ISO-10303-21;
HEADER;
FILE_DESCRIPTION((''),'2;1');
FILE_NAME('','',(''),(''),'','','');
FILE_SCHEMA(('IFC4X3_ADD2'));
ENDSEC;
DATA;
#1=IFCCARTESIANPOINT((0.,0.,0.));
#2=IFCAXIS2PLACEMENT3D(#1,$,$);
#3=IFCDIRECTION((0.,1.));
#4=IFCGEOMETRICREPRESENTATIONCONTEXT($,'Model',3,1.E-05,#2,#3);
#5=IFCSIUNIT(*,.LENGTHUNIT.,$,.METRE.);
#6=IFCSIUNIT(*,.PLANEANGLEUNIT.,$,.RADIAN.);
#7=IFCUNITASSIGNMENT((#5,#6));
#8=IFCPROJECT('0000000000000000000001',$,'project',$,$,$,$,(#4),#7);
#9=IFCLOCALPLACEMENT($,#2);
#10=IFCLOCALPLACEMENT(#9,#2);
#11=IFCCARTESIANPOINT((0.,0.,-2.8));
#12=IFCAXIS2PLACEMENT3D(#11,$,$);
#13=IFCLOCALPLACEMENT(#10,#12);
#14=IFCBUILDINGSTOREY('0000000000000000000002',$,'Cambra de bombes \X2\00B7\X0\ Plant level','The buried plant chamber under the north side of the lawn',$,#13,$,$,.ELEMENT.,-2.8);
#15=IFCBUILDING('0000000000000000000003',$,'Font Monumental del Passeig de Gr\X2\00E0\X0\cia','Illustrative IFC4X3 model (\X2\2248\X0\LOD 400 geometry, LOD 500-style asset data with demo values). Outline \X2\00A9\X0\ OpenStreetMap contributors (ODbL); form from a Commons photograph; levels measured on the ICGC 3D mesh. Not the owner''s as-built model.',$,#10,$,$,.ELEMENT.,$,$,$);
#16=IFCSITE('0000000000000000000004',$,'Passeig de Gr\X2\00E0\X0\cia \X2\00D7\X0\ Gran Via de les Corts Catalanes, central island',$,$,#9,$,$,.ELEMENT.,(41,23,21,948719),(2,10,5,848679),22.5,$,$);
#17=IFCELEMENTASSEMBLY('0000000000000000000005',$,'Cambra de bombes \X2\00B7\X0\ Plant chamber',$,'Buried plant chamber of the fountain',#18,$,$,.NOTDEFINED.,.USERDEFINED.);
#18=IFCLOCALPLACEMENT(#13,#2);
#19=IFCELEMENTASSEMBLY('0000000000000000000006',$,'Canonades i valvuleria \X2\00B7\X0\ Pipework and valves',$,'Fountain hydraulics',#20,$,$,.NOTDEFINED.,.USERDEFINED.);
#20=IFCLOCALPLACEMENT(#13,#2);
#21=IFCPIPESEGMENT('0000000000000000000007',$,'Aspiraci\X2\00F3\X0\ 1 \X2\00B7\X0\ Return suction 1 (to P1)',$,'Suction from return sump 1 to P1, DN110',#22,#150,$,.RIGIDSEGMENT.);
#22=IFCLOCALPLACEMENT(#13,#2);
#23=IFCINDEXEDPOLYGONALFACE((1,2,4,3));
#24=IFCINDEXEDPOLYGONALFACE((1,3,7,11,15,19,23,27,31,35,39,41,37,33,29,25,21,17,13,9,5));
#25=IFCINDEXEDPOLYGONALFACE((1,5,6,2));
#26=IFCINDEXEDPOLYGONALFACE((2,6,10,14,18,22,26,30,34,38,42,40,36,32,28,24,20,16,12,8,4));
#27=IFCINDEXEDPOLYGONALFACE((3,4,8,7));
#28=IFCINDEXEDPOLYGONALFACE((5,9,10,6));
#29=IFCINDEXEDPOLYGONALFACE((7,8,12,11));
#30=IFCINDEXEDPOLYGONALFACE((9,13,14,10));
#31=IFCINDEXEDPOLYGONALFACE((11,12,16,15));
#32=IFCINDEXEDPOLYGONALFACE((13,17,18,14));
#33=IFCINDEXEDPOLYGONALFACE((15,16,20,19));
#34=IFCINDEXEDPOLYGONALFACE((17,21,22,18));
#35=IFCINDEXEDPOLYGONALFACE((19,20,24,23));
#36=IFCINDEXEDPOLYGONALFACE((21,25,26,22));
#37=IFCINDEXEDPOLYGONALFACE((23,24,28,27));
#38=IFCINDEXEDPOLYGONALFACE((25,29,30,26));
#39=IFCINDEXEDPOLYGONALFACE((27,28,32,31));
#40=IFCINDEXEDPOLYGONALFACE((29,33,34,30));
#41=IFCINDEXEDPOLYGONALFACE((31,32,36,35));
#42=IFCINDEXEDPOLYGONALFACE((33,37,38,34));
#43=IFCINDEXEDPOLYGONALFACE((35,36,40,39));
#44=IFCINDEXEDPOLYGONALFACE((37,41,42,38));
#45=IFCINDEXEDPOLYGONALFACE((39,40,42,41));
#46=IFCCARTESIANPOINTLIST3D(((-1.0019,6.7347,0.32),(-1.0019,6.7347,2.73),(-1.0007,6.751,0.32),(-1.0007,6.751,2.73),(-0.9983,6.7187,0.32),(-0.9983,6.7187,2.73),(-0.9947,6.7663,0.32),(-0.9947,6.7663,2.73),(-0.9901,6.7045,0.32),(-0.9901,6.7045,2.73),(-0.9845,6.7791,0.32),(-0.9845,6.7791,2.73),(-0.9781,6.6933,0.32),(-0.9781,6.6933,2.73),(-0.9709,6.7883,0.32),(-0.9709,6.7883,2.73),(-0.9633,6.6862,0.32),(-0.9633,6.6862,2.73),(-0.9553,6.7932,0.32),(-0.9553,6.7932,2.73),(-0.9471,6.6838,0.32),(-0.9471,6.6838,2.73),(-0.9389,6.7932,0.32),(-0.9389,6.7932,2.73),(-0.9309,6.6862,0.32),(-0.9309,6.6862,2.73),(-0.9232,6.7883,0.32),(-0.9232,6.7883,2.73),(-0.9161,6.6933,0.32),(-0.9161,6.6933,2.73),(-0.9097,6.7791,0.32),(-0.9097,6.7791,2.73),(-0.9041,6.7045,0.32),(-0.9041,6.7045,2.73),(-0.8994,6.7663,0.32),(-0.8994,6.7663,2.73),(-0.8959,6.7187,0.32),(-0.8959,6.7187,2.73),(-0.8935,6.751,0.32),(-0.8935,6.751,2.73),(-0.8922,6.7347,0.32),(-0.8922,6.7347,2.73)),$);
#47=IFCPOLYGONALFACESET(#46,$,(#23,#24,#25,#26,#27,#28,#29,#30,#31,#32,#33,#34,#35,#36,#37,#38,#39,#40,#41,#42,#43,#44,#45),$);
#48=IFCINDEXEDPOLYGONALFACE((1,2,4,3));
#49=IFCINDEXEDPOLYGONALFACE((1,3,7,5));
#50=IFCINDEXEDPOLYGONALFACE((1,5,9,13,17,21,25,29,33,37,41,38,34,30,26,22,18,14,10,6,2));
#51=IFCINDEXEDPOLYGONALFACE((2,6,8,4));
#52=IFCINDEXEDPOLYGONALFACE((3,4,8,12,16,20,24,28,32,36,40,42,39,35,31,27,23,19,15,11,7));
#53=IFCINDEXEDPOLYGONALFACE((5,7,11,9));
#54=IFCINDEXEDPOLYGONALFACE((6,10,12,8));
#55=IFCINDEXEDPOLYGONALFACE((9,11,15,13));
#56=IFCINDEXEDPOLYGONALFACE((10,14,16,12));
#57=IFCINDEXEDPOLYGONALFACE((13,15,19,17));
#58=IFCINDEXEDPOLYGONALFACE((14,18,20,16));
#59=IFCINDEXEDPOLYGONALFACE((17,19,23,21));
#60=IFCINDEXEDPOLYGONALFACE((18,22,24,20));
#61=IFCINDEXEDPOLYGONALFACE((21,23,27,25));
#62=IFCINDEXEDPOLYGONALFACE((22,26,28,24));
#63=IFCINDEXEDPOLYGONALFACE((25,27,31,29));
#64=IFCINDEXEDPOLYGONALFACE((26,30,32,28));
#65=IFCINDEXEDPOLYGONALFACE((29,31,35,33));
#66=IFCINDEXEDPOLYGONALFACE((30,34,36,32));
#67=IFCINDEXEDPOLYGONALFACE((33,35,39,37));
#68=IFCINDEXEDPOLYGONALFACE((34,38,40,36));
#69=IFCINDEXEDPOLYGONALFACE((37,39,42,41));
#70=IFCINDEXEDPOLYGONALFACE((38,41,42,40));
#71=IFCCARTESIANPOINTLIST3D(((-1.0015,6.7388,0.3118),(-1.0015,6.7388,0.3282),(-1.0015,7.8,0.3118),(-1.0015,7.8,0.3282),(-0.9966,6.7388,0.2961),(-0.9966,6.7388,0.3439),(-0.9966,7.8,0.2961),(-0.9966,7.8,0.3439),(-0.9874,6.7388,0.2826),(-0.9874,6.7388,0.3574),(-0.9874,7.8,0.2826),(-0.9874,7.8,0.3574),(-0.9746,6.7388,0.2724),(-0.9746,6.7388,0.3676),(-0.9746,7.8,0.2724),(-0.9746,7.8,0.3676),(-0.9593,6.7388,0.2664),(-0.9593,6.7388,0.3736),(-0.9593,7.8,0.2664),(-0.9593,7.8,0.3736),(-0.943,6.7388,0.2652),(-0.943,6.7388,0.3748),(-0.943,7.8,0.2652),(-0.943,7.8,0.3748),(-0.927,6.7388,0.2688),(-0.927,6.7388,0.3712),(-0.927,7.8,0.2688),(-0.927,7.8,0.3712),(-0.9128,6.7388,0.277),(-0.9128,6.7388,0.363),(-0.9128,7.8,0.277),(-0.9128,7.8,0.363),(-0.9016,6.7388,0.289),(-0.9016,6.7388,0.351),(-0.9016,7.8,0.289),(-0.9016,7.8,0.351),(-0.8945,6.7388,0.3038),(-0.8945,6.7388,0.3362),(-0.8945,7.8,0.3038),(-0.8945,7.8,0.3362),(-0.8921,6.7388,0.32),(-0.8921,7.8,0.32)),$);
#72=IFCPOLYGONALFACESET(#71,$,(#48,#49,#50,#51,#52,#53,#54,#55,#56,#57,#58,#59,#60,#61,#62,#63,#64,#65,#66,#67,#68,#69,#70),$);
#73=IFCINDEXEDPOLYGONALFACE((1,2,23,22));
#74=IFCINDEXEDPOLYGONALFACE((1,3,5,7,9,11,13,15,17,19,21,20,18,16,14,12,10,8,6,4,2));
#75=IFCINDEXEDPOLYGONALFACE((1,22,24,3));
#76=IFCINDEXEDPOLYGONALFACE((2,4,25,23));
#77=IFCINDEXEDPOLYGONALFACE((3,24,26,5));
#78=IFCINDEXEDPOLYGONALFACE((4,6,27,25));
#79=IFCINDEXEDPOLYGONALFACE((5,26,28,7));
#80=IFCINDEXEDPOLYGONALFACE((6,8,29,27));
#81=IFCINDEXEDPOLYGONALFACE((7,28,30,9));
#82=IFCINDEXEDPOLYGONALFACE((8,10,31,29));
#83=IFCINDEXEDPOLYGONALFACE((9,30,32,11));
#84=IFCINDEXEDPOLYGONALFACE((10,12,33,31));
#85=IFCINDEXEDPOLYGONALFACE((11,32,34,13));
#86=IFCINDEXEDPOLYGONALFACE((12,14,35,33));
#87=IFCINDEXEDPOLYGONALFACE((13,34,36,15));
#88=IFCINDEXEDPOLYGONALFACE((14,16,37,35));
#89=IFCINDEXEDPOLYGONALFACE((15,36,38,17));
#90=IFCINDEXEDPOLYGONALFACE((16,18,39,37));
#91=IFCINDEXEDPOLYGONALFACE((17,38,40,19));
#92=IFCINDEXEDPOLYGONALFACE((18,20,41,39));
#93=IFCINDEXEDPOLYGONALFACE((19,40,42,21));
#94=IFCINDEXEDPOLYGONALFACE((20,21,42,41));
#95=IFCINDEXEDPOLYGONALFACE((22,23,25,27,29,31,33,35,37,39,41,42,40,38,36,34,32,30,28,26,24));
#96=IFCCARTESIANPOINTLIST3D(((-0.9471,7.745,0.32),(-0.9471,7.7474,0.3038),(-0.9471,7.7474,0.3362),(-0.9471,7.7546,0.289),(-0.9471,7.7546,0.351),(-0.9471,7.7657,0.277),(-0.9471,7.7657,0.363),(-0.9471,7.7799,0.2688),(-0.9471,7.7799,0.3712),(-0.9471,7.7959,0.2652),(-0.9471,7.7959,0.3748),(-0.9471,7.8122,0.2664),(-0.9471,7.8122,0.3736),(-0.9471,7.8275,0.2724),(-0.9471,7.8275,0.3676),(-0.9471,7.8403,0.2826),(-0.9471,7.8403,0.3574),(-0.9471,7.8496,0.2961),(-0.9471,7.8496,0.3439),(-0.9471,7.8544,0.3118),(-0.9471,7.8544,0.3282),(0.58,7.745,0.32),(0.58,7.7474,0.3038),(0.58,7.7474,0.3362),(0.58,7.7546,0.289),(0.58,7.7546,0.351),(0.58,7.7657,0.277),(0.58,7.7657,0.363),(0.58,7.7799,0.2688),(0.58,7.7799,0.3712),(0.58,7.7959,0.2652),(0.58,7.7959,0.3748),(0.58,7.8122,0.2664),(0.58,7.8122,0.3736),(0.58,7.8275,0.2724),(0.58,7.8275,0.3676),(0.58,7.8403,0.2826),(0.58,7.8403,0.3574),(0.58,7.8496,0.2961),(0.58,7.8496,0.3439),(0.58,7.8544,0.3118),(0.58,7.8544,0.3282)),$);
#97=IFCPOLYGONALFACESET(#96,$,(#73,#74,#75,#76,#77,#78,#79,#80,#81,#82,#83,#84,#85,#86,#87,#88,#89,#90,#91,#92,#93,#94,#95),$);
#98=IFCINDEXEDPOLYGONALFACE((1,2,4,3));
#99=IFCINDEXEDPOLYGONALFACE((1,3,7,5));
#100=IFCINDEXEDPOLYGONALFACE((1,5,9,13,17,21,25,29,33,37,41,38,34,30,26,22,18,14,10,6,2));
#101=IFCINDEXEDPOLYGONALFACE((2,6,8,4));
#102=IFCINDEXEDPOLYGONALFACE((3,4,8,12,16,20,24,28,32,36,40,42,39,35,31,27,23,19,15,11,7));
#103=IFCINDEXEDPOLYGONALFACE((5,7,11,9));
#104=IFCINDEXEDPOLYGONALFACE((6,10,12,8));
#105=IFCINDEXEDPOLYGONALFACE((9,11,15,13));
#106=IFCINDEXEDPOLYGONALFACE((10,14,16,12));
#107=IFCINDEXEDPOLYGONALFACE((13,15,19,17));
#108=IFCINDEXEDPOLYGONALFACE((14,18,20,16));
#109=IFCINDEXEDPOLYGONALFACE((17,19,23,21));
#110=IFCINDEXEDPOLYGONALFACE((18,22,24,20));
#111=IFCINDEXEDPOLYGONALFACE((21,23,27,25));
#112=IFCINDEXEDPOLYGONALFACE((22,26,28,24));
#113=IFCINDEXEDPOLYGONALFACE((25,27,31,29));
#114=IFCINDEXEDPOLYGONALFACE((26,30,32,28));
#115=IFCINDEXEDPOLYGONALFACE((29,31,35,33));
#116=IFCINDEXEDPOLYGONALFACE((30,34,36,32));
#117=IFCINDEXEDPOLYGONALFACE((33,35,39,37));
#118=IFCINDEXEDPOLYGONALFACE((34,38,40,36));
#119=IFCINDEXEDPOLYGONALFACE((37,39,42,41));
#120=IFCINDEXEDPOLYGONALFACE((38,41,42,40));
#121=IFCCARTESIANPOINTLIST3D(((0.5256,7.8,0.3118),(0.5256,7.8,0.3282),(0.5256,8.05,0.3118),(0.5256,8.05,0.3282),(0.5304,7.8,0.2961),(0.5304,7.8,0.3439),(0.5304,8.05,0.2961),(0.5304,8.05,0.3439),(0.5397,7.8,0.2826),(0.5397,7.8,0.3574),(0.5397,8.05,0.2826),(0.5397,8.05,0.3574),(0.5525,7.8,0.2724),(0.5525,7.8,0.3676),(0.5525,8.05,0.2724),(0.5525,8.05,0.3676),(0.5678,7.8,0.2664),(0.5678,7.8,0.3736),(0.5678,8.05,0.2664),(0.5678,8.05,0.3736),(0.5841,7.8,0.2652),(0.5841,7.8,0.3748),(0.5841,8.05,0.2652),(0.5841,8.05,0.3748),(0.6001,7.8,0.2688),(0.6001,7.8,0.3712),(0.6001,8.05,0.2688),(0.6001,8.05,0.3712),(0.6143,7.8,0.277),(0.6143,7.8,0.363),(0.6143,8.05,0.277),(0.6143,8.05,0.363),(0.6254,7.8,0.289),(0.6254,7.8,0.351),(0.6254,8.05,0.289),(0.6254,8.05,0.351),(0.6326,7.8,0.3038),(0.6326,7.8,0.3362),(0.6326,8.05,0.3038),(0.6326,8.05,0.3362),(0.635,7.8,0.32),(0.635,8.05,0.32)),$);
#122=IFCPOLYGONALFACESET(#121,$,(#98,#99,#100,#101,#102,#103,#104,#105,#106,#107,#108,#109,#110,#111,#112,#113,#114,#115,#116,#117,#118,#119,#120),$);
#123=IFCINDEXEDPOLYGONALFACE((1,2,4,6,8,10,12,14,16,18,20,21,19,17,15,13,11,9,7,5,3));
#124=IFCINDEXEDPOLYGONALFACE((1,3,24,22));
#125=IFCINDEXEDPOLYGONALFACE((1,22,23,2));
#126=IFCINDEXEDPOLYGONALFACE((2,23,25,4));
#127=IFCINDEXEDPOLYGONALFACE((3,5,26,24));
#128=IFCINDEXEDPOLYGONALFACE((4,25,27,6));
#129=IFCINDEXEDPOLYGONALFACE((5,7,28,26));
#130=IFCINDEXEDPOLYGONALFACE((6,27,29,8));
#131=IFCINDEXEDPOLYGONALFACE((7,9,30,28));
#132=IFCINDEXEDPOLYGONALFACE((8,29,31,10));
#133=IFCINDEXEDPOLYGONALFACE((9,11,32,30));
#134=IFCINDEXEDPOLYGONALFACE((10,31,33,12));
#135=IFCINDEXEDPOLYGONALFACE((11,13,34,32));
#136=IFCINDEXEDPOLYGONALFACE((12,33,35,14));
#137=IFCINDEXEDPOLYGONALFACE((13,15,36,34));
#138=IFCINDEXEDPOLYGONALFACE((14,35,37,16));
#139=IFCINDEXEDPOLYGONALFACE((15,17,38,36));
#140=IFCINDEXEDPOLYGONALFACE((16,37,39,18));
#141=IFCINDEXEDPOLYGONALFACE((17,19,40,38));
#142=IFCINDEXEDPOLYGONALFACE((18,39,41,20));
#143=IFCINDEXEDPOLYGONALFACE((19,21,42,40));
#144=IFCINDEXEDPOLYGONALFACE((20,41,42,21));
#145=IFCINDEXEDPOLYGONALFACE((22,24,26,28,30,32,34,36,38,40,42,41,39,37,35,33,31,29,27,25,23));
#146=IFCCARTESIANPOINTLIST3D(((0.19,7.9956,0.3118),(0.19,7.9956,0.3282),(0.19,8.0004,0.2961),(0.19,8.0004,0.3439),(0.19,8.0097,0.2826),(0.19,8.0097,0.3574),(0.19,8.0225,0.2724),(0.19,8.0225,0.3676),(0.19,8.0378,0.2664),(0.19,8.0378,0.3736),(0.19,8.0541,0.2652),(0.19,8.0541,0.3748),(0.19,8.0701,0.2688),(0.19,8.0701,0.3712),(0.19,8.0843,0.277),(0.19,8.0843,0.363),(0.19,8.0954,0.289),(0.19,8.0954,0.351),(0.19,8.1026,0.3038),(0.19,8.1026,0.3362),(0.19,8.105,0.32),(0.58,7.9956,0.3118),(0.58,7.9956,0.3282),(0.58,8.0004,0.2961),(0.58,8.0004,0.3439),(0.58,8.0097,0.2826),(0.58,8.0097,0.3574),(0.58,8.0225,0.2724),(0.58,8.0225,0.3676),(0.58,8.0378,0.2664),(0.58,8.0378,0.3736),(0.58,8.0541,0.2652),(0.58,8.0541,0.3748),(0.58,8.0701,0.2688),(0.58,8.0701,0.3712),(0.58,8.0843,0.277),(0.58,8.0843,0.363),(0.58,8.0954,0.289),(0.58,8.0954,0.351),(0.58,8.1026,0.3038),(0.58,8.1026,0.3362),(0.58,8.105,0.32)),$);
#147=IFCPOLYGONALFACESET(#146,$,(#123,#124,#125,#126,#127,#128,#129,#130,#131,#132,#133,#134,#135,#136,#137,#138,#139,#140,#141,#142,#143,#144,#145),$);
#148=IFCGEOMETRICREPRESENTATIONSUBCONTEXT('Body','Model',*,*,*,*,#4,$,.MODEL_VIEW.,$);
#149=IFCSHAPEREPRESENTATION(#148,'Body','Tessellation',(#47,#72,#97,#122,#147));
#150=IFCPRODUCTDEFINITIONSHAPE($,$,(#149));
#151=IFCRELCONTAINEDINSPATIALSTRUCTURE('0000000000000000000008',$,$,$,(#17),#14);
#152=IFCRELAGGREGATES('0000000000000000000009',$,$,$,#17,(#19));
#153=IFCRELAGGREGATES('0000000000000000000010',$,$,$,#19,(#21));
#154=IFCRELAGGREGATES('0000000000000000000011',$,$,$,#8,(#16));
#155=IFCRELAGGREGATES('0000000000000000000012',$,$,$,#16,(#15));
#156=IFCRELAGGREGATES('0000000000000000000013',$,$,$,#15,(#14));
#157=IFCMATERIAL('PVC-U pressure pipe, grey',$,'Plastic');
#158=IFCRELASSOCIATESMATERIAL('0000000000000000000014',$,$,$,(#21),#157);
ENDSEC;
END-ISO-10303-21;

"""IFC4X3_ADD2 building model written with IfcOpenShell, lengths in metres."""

from ifc_helpers import new_model, si_unit, direction, frame, origin, origin_2d_with_axis, place, context, subcontext, project, spatial, circle, extrude, material, element, aggregate, save


model = new_model("IFC4X3_ADD2")

# Units and contexts
model_context = context("Model", 3, precision=1e-05, world=origin(), true_north=direction((0.0, 1.0)))
body_context = subcontext(model_context, "Body", "Model", "MODEL_VIEW")
ifc_project = project(units=[si_unit("LENGTHUNIT", "METRE"), si_unit("PLANEANGLEUNIT", "RADIAN")], contexts=[model_context])

# Site, building, storey
site_placement = place(None, origin())
site = spatial("IfcSite", under=ifc_project, at=site_placement, Name="Passeig de Gràcia × Gran Via de les Corts Catalanes, central island", CompositionType="ELEMENT", RefLatitude=(41, 23, 21, 948719), RefLongitude=(2, 10, 5, 848679), RefElevation=22.5)
building_placement = place(site_placement, origin())
building = spatial("IfcBuilding", under=site, at=building_placement, Name="Font Monumental del Passeig de Gràcia", Description="Illustrative IFC4X3 model (≈LOD 400 geometry, LOD 500-style asset data with demo values). Outline © OpenStreetMap contributors (ODbL); form from a Commons photograph; levels measured on the ICGC 3D mesh. Not the owner's as-built model.", CompositionType="ELEMENT")
storey_placement = place(building_placement, frame((0.0, 0.0, -2.8)))
storey = spatial("IfcBuildingStorey", under=building, at=storey_placement, Name="Cambra de bombes · Plant level", Description="The buried plant chamber under the north side of the lawn", CompositionType="ELEMENT", Elevation=-2.8)

# Element assemblies, pipe segment
assembly_1_placement = place(building_placement, origin())
assembly_1 = element("IfcElementAssembly", 1, at=assembly_1_placement, inside=storey, Name="Cambra de bombes · Plant chamber", ObjectType="Buried plant chamber of the fountain", AssemblyPlace="NOTDEFINED", PredefinedType="USERDEFINED")
assembly_2_placement = place(building_placement, origin())
assembly_2 = element("IfcElementAssembly", 2, at=assembly_2_placement, Name="Canonades i valvuleria · Pipework and valves", ObjectType="Fountain hydraulics", AssemblyPlace="NOTDEFINED", PredefinedType="USERDEFINED")
aggregate(assembly_1, [assembly_2])
ifc_material_1 = material(Name="PVC-U pressure pipe, grey", Category="Plastic")
pipe_segment_1_placement = place(building_placement, origin())
pipe_segment_1 = element("IfcPipeSegment", 3, at=pipe_segment_1_placement, material=ifc_material_1, Name="Aspiració 1 · Return suction 1 (to P1)", ObjectType="Suction from return sump 1 to P1, DN110", PredefinedType="RIGIDSEGMENT", context=body_context, shape_type="SweptSolid", body=[
    extrude(circle(Radius=0.055, at=origin_2d_with_axis()), frame((-0.9471, 6.7388, -0.07), z_axis=(0.0, 0.0, -1.0), x_axis=(0.0, -1.0, 0.0)), (0.0, 0.0, 1.0), 2.41),
    extrude(circle(Radius=0.055, at=origin_2d_with_axis()), frame((-0.9471, 6.7388, -2.48), z_axis=(0.0, 1.0, 0.0), x_axis=(1.0, 0.0, 0.0)), (0.0, 0.0, 1.0), 1.0612),
    extrude(circle(Radius=0.055, at=origin_2d_with_axis()), frame((-0.9471, 7.8, -2.48), z_axis=(1.0, 0.0, 0.0), x_axis=(0.0, -1.0, 0.0)), (0.0, 0.0, 1.0), 1.5271),
    extrude(circle(Radius=0.055, at=origin_2d_with_axis()), frame((0.58, 7.8, -2.48), z_axis=(0.0, 1.0, 0.0), x_axis=(1.0, 0.0, 0.0)), (0.0, 0.0, 1.0), 0.25),
    extrude(circle(Radius=0.055, at=origin_2d_with_axis()), frame((0.58, 8.05, -2.48), z_axis=(-1.0, 0.0, 0.0), x_axis=(0.0, 1.0, 0.0)), (0.0, 0.0, 1.0), 0.39),
])
aggregate(assembly_2, [pipe_segment_1])

save(model, "model.ifc")
